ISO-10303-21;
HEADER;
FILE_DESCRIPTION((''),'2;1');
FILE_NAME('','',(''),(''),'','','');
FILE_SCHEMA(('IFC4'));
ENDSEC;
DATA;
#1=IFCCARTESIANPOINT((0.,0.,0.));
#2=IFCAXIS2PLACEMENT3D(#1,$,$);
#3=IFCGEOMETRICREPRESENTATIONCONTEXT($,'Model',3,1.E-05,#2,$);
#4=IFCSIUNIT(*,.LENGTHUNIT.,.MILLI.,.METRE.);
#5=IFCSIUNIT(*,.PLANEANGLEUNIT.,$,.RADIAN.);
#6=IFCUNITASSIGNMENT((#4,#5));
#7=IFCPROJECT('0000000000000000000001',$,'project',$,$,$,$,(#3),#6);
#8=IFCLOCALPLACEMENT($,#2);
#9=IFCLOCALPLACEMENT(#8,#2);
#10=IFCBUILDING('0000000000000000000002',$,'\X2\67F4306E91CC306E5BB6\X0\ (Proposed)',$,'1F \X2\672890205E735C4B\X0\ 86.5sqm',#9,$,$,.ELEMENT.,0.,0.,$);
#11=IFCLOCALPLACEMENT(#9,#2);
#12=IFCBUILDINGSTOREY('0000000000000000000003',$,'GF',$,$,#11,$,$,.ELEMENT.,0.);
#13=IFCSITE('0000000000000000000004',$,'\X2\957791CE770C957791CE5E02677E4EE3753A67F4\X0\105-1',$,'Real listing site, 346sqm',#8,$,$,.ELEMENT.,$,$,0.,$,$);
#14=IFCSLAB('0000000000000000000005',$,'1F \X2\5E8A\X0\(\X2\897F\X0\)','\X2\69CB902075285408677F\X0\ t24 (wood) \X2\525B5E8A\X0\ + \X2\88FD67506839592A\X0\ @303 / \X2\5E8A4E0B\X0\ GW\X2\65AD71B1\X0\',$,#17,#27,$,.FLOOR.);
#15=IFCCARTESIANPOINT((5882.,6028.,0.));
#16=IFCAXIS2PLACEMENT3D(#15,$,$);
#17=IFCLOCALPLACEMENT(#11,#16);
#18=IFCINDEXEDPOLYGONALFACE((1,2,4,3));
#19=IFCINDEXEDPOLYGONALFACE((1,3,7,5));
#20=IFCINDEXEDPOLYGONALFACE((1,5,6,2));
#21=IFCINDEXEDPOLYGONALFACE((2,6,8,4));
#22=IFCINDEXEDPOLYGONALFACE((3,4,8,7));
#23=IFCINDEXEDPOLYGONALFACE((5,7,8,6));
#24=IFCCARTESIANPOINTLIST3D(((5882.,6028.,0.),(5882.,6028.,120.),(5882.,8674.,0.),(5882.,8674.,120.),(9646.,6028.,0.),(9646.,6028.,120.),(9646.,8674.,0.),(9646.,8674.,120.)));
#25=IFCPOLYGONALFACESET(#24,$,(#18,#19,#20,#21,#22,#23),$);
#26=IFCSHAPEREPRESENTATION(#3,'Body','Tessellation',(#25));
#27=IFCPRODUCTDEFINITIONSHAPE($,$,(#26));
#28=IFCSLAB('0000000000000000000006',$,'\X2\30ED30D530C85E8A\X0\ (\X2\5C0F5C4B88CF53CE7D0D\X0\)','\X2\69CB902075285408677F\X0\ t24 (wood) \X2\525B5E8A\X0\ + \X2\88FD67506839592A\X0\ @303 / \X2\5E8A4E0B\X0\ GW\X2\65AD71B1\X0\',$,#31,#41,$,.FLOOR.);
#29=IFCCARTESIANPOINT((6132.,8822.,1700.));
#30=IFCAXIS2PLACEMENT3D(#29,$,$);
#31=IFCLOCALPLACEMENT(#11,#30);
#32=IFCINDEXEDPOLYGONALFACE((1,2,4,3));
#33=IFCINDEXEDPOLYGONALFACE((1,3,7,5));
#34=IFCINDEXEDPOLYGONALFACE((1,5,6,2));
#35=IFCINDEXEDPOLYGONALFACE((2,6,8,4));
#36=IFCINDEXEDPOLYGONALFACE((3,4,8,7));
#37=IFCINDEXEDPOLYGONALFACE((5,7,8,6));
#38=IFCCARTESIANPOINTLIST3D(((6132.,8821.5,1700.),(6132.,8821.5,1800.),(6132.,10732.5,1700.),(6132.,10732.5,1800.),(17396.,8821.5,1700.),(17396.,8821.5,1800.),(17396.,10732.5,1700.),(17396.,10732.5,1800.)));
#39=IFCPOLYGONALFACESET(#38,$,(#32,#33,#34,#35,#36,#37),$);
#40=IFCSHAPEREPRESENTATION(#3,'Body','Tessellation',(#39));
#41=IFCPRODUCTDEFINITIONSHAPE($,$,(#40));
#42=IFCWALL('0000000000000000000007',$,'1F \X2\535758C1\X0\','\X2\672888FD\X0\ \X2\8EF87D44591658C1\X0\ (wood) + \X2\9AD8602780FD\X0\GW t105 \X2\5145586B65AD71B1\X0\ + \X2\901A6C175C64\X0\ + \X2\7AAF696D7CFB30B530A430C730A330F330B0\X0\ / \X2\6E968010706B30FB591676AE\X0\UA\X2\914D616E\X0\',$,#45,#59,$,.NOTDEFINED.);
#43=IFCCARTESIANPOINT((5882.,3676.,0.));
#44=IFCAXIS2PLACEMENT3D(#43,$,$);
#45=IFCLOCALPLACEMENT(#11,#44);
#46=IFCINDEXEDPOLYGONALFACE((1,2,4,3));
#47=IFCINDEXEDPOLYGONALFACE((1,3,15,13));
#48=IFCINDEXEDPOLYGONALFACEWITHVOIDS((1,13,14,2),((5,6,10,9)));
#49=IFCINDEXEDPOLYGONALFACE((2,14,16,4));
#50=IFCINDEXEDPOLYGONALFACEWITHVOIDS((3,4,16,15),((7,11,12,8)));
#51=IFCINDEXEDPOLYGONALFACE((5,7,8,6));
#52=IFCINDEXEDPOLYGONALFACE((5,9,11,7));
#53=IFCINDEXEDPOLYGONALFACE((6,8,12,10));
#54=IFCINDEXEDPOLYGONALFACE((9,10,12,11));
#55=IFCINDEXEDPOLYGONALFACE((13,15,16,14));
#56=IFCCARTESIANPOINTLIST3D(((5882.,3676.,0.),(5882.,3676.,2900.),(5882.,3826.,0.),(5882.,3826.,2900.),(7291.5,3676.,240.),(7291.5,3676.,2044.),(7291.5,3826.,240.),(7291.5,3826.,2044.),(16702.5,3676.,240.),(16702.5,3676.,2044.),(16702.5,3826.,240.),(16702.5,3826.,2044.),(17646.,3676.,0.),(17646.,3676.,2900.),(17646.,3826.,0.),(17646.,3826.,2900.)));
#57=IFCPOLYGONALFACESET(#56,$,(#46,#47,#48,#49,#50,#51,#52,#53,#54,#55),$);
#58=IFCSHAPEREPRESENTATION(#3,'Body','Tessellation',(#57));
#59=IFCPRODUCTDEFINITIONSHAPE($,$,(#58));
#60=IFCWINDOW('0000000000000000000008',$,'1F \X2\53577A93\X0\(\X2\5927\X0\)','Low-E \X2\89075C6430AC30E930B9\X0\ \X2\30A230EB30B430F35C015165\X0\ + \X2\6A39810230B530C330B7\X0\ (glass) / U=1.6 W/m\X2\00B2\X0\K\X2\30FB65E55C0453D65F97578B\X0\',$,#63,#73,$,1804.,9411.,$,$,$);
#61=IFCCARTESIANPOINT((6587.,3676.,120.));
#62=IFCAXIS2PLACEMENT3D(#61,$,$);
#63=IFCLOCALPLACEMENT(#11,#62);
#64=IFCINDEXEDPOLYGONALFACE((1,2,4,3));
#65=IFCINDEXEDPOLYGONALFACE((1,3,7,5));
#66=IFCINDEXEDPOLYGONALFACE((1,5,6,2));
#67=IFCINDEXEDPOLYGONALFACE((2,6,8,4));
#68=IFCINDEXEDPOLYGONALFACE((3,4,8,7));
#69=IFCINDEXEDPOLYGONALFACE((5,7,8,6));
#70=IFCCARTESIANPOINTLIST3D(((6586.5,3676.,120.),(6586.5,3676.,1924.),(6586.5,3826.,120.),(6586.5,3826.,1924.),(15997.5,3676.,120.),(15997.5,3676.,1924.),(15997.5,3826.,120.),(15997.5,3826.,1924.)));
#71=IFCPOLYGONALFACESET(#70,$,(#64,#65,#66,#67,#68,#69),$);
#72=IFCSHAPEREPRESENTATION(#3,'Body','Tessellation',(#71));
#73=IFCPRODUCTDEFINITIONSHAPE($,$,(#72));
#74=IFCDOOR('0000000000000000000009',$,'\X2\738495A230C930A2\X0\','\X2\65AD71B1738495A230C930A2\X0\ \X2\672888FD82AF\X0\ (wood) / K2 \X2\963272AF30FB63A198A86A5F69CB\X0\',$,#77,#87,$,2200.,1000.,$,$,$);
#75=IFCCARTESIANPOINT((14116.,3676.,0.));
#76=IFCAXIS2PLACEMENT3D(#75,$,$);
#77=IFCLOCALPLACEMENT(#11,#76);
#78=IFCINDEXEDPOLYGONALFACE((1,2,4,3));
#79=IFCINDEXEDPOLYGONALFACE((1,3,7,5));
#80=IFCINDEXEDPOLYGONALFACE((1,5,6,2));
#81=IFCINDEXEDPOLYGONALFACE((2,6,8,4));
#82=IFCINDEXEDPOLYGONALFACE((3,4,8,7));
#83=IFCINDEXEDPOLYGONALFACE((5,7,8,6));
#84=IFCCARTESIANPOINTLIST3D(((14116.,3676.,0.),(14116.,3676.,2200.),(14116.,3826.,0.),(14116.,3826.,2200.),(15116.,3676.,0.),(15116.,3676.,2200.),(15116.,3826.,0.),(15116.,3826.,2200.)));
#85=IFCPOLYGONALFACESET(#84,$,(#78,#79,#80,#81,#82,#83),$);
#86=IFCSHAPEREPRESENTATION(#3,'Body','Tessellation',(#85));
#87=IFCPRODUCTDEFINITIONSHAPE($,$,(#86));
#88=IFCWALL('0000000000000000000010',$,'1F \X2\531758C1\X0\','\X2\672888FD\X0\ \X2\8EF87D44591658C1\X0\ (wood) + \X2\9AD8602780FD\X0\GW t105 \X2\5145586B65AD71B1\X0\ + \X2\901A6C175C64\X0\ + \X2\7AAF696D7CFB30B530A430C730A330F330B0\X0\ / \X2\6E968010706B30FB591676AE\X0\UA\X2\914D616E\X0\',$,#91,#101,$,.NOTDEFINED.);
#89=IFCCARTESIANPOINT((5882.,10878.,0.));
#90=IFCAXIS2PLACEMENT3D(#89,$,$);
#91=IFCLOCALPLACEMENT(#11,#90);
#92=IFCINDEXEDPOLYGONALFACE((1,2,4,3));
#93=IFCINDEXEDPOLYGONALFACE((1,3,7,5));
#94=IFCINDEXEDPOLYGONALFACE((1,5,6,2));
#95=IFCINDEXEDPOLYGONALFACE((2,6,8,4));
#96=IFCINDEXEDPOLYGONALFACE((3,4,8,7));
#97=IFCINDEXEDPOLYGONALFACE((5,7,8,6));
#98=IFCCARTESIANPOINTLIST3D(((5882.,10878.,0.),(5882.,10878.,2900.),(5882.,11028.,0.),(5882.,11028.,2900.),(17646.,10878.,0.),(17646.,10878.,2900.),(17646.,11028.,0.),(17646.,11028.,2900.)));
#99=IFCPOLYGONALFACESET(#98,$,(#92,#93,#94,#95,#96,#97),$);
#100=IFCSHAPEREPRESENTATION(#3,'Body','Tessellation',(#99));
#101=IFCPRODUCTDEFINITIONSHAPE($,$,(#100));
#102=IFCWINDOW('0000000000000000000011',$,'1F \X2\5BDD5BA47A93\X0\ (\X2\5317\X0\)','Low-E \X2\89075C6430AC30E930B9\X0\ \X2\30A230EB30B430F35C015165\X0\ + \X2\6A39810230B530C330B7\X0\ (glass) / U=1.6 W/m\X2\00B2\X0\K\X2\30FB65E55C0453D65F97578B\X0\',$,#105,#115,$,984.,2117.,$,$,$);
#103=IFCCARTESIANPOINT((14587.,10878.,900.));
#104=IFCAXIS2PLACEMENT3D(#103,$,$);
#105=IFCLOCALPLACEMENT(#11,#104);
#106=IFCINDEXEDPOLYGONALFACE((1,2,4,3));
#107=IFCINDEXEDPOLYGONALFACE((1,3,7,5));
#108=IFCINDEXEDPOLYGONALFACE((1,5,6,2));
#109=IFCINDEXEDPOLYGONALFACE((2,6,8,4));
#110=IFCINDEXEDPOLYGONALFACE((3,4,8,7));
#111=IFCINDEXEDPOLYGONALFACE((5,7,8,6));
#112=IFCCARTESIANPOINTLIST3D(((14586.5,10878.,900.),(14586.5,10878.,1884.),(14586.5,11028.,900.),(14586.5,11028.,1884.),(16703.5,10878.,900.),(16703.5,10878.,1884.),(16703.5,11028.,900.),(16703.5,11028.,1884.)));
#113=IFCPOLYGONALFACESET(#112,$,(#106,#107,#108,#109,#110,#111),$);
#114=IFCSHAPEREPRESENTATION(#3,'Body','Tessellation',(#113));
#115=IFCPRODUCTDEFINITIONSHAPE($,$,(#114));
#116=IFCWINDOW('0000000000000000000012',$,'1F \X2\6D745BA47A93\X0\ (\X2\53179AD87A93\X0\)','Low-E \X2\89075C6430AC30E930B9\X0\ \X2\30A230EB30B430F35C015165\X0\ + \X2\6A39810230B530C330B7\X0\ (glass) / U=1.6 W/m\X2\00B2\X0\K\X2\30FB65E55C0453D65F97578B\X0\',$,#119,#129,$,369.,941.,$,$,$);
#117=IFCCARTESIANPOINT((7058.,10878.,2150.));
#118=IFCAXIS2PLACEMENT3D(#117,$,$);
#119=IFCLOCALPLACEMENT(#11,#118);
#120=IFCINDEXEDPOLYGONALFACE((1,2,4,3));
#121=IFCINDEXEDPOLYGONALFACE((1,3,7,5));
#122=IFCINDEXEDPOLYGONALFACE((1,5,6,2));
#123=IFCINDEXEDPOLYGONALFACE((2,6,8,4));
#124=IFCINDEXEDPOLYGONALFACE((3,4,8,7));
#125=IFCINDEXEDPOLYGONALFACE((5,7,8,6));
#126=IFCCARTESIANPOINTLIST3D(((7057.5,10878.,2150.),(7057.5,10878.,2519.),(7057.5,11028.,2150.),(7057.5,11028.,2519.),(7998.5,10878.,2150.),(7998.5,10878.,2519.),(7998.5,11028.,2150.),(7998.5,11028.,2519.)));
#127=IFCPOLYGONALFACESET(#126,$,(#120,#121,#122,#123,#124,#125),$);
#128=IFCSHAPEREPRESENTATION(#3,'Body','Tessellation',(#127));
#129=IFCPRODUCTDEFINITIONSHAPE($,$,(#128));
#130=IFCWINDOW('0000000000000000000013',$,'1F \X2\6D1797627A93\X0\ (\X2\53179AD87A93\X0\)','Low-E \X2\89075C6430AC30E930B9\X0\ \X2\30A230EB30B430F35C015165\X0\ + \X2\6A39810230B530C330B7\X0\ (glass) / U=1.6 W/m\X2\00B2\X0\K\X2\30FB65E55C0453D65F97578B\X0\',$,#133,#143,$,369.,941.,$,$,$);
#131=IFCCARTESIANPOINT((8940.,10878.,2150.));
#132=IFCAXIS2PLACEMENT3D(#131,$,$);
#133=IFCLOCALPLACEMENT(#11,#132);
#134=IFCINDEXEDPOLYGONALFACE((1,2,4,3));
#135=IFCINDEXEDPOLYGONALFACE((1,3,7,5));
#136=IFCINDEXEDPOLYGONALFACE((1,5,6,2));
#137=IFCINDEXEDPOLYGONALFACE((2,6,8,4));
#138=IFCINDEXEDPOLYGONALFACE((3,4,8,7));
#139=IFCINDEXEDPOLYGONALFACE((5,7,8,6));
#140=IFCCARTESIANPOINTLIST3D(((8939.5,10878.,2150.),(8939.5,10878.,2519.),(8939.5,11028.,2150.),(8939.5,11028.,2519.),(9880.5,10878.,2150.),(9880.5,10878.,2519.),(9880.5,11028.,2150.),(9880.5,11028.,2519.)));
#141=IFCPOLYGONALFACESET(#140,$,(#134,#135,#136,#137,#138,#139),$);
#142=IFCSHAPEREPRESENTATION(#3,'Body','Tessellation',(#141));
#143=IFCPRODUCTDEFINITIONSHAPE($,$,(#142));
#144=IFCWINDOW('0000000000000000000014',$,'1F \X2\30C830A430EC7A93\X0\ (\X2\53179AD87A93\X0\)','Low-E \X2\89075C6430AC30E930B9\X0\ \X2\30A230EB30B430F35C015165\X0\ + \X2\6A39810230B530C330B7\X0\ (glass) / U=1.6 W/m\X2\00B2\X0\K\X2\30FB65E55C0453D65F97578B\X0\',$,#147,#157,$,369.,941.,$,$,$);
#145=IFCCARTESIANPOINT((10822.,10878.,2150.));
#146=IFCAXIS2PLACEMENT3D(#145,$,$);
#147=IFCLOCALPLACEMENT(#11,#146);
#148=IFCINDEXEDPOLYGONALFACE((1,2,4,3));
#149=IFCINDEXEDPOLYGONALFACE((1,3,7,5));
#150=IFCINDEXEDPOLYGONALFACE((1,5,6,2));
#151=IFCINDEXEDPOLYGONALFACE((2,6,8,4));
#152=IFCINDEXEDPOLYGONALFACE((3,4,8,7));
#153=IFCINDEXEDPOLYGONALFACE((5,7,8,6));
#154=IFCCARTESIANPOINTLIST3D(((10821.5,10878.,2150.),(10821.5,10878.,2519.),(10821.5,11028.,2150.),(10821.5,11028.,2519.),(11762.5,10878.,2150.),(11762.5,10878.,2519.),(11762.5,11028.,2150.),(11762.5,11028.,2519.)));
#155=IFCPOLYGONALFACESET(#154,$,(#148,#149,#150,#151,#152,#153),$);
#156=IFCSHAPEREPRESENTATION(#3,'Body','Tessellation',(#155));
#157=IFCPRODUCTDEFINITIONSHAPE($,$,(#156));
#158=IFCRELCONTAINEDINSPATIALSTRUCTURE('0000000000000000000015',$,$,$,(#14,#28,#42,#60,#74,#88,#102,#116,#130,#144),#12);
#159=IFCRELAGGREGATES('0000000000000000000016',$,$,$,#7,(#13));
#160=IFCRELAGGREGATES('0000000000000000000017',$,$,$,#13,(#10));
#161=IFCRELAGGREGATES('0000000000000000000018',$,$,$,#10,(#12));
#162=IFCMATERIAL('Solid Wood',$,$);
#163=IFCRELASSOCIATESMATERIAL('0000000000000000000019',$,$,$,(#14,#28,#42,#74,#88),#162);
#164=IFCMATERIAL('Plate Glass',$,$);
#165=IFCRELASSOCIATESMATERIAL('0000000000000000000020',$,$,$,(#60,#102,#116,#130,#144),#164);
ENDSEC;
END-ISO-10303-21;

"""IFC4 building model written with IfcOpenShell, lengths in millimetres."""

from ifc_helpers import new_model, si_unit, frame, frame_2d, origin, place, context, project, spatial, rectangle, extrude, material, element, fill, save


model = new_model("IFC4")

# Units and contexts
model_context = context("Model", 3, precision=1e-05, world=origin())
ifc_project = project(units=[si_unit("LENGTHUNIT", "METRE", prefix="MILLI"), si_unit("PLANEANGLEUNIT", "RADIAN")], contexts=[model_context])

# Site, building, storey
site_placement = place(None, origin())
site = spatial("IfcSite", under=ifc_project, at=site_placement, Name="長野県長野市松代町柴105-1", ObjectType="Real listing site, 346sqm", CompositionType="ELEMENT", RefElevation=0.0)
building_placement = place(site_placement, origin())
building = spatial("IfcBuilding", under=site, at=building_placement, Name="柴の里の家 (Proposed)", ObjectType="1F 木造平屋 86.5sqm", CompositionType="ELEMENT", ElevationOfRefHeight=0.0, ElevationOfTerrain=0.0)
storey_placement = place(building_placement, origin())
storey = spatial("IfcBuildingStorey", under=building, at=storey_placement, Name="GF", CompositionType="ELEMENT", Elevation=0.0)

# Slabs
ifc_material_1 = material(Name="Solid Wood")
slab_1_placement = place(storey_placement, frame((5882.0, 6028.0, 0.0)))
element("IfcSlab", 1, at=slab_1_placement, inside=storey, material=ifc_material_1, Name="1F 床(西)", Description="構造用合板 t24 (wood) 剛床 + 製材根太 @303 / 床下 GW断熱", PredefinedType="FLOOR", context=model_context, shape_type="SweptSolid", body=[
    extrude(rectangle(XDim=3764.0, YDim=2646.0, at=frame_2d((1882.0, 1323.0))), frame((5882.0, 6028.0, 0.0)), (0.0, 0.0, 1.0), 120.0),
])
slab_2_placement = place(storey_placement, frame((6132.0, 8822.0, 1700.0)))
element("IfcSlab", 2, at=slab_2_placement, inside=storey, material=ifc_material_1, Name="ロフト床 (小屋裏収納)", Description="構造用合板 t24 (wood) 剛床 + 製材根太 @303 / 床下 GW断熱", PredefinedType="FLOOR", context=model_context, shape_type="SweptSolid", body=[
    extrude(rectangle(XDim=11264.0, YDim=1911.0, at=frame_2d((5632.0, 955.0))), frame((6132.0, 8822.0, 1700.0)), (0.0, 0.0, 1.0), 100.0),
])

# Wall, openings, window, door
wall_1_placement = place(storey_placement, frame((5882.0, 3676.0, 0.0)))
wall_1 = element("IfcWall", 3, at=wall_1_placement, inside=storey, material=ifc_material_1, Name="1F 南壁", Description="木製 軸組外壁 (wood) + 高性能GW t105 充填断熱 + 通気層 + 窯業系サイディング / 準耐火・外皮UA配慮", PredefinedType="NOTDEFINED", context=model_context, shape_type="SweptSolid", body=[
    extrude(rectangle(XDim=11764.0, YDim=150.0, at=frame_2d((5882.0, 75.0))), frame((5882.0, 3676.0, 0.0)), (0.0, 0.0, 1.0), 2900.0),
])
opening_1_placement = place(storey_placement, frame((6587.0, 3676.0, 120.0)))
opening_1 = element("IfcOpeningElement", 4, at=opening_1_placement, cuts=wall_1, PredefinedType="NOTDEFINED", context=model_context, shape_type="SweptSolid", body=[
    extrude(rectangle(XDim=9411.0, YDim=150.0, at=frame_2d((4705.0, 75.0))), frame((6587.0, 3676.0, 120.0)), (0.0, 0.0, 1.0), 1804.0),
])
opening_2_placement = place(storey_placement, frame((14116.0, 3676.0, 0.0)))
opening_2 = element("IfcOpeningElement", 5, at=opening_2_placement, cuts=wall_1, PredefinedType="NOTDEFINED", context=model_context, shape_type="SweptSolid", body=[
    extrude(rectangle(XDim=1000.0, YDim=150.0, at=frame_2d((500.0, 75.0))), frame((14116.0, 3676.0, 0.0)), (0.0, 0.0, 1.0), 2200.0),
])
ifc_material_2 = material(Name="Plate Glass")
window_1_placement = place(storey_placement, frame((6587.0, 3676.0, 120.0)))
window_1 = element("IfcWindow", 6, at=window_1_placement, inside=storey, material=ifc_material_2, Name="1F 南窓(大)", Description="Low-E 複層ガラス アルゴン封入 + 樹脂サッシ (glass) / U=1.6 W/m²K・日射取得型", OverallHeight=1804.0, OverallWidth=9411.0, context=model_context, shape_type="SweptSolid", body=[
    extrude(rectangle(XDim=9411.0, YDim=150.0, at=frame_2d((4705.0, 75.0))), frame((6587.0, 3676.0, 120.0)), (0.0, 0.0, 1.0), 1804.0),
])
fill(opening_1, window_1)
door_1_placement = place(storey_placement, frame((14116.0, 3676.0, 0.0)))
door_1 = element("IfcDoor", 7, at=door_1_placement, inside=storey, material=ifc_material_1, Name="玄関ドア", Description="断熱玄関ドア 木製芯 (wood) / K2 防犯・採風機構", OverallHeight=2200.0, OverallWidth=1000.0, context=model_context, shape_type="SweptSolid", body=[
    extrude(rectangle(XDim=1000.0, YDim=150.0, at=frame_2d((500.0, 75.0))), frame((14116.0, 3676.0, 0.0)), (0.0, 0.0, 1.0), 2200.0),
])
fill(opening_2, door_1)

# Wall, openings, windows
wall_2_placement = place(storey_placement, frame((5882.0, 10878.0, 0.0)))
wall_2 = element("IfcWall", 8, at=wall_2_placement, inside=storey, material=ifc_material_1, Name="1F 北壁", Description="木製 軸組外壁 (wood) + 高性能GW t105 充填断熱 + 通気層 + 窯業系サイディング / 準耐火・外皮UA配慮", PredefinedType="NOTDEFINED", context=model_context, shape_type="SweptSolid", body=[
    extrude(rectangle(XDim=11764.0, YDim=150.0, at=frame_2d((5882.0, 75.0))), frame((5882.0, 10878.0, 0.0)), (0.0, 0.0, 1.0), 2900.0),
])
opening_3_placement = place(storey_placement, frame((14587.0, 10878.0, 900.0)))
opening_3 = element("IfcOpeningElement", 9, at=opening_3_placement, cuts=wall_2, PredefinedType="NOTDEFINED", context=model_context, shape_type="SweptSolid", body=[
    extrude(rectangle(XDim=2117.0, YDim=150.0, at=frame_2d((1058.0, 75.0))), frame((14587.0, 10878.0, 900.0)), (0.0, 0.0, 1.0), 984.0),
])
opening_4_placement = place(storey_placement, frame((7058.0, 10878.0, 2150.0)))
opening_4 = element("IfcOpeningElement", 10, at=opening_4_placement, cuts=wall_2, PredefinedType="NOTDEFINED", context=model_context, shape_type="SweptSolid", body=[
    extrude(rectangle(XDim=941.0, YDim=150.0, at=frame_2d((470.0, 75.0))), frame((7058.0, 10878.0, 2150.0)), (0.0, 0.0, 1.0), 369.0),
])
opening_5_placement = place(storey_placement, frame((8940.0, 10878.0, 2150.0)))
opening_5 = element("IfcOpeningElement", 11, at=opening_5_placement, cuts=wall_2, PredefinedType="NOTDEFINED", context=model_context, shape_type="SweptSolid", body=[
    extrude(rectangle(XDim=941.0, YDim=150.0, at=frame_2d((470.0, 75.0))), frame((8940.0, 10878.0, 2150.0)), (0.0, 0.0, 1.0), 369.0),
])
opening_6_placement = place(storey_placement, frame((10822.0, 10878.0, 2150.0)))
opening_6 = element("IfcOpeningElement", 12, at=opening_6_placement, cuts=wall_2, PredefinedType="NOTDEFINED", context=model_context, shape_type="SweptSolid", body=[
    extrude(rectangle(XDim=941.0, YDim=150.0, at=frame_2d((470.0, 75.0))), frame((10822.0, 10878.0, 2150.0)), (0.0, 0.0, 1.0), 369.0),
])
window_2_placement = place(storey_placement, frame((14587.0, 10878.0, 900.0)))
window_2 = element("IfcWindow", 13, at=window_2_placement, inside=storey, material=ifc_material_2, Name="1F 寝室窓 (北)", Description="Low-E 複層ガラス アルゴン封入 + 樹脂サッシ (glass) / U=1.6 W/m²K・日射取得型", OverallHeight=984.0, OverallWidth=2117.0, context=model_context, shape_type="SweptSolid", body=[
    extrude(rectangle(XDim=2117.0, YDim=150.0, at=frame_2d((1058.0, 75.0))), frame((14587.0, 10878.0, 900.0)), (0.0, 0.0, 1.0), 984.0),
])
fill(opening_3, window_2)
window_3_placement = place(storey_placement, frame((7058.0, 10878.0, 2150.0)))
window_3 = element("IfcWindow", 14, at=window_3_placement, inside=storey, material=ifc_material_2, Name="1F 浴室窓 (北高窓)", Description="Low-E 複層ガラス アルゴン封入 + 樹脂サッシ (glass) / U=1.6 W/m²K・日射取得型", OverallHeight=369.0, OverallWidth=941.0, context=model_context, shape_type="SweptSolid", body=[
    extrude(rectangle(XDim=941.0, YDim=150.0, at=frame_2d((470.0, 75.0))), frame((7058.0, 10878.0, 2150.0)), (0.0, 0.0, 1.0), 369.0),
])
fill(opening_4, window_3)
window_4_placement = place(storey_placement, frame((8940.0, 10878.0, 2150.0)))
window_4 = element("IfcWindow", 15, at=window_4_placement, inside=storey, material=ifc_material_2, Name="1F 洗面窓 (北高窓)", Description="Low-E 複層ガラス アルゴン封入 + 樹脂サッシ (glass) / U=1.6 W/m²K・日射取得型", OverallHeight=369.0, OverallWidth=941.0, context=model_context, shape_type="SweptSolid", body=[
    extrude(rectangle(XDim=941.0, YDim=150.0, at=frame_2d((470.0, 75.0))), frame((8940.0, 10878.0, 2150.0)), (0.0, 0.0, 1.0), 369.0),
])
fill(opening_5, window_4)
window_5_placement = place(storey_placement, frame((10822.0, 10878.0, 2150.0)))
window_5 = element("IfcWindow", 16, at=window_5_placement, inside=storey, material=ifc_material_2, Name="1F トイレ窓 (北高窓)", Description="Low-E 複層ガラス アルゴン封入 + 樹脂サッシ (glass) / U=1.6 W/m²K・日射取得型", OverallHeight=369.0, OverallWidth=941.0, context=model_context, shape_type="SweptSolid", body=[
    extrude(rectangle(XDim=941.0, YDim=150.0, at=frame_2d((470.0, 75.0))), frame((10822.0, 10878.0, 2150.0)), (0.0, 0.0, 1.0), 369.0),
])
fill(opening_6, window_5)

save(model, "model.ifc")
